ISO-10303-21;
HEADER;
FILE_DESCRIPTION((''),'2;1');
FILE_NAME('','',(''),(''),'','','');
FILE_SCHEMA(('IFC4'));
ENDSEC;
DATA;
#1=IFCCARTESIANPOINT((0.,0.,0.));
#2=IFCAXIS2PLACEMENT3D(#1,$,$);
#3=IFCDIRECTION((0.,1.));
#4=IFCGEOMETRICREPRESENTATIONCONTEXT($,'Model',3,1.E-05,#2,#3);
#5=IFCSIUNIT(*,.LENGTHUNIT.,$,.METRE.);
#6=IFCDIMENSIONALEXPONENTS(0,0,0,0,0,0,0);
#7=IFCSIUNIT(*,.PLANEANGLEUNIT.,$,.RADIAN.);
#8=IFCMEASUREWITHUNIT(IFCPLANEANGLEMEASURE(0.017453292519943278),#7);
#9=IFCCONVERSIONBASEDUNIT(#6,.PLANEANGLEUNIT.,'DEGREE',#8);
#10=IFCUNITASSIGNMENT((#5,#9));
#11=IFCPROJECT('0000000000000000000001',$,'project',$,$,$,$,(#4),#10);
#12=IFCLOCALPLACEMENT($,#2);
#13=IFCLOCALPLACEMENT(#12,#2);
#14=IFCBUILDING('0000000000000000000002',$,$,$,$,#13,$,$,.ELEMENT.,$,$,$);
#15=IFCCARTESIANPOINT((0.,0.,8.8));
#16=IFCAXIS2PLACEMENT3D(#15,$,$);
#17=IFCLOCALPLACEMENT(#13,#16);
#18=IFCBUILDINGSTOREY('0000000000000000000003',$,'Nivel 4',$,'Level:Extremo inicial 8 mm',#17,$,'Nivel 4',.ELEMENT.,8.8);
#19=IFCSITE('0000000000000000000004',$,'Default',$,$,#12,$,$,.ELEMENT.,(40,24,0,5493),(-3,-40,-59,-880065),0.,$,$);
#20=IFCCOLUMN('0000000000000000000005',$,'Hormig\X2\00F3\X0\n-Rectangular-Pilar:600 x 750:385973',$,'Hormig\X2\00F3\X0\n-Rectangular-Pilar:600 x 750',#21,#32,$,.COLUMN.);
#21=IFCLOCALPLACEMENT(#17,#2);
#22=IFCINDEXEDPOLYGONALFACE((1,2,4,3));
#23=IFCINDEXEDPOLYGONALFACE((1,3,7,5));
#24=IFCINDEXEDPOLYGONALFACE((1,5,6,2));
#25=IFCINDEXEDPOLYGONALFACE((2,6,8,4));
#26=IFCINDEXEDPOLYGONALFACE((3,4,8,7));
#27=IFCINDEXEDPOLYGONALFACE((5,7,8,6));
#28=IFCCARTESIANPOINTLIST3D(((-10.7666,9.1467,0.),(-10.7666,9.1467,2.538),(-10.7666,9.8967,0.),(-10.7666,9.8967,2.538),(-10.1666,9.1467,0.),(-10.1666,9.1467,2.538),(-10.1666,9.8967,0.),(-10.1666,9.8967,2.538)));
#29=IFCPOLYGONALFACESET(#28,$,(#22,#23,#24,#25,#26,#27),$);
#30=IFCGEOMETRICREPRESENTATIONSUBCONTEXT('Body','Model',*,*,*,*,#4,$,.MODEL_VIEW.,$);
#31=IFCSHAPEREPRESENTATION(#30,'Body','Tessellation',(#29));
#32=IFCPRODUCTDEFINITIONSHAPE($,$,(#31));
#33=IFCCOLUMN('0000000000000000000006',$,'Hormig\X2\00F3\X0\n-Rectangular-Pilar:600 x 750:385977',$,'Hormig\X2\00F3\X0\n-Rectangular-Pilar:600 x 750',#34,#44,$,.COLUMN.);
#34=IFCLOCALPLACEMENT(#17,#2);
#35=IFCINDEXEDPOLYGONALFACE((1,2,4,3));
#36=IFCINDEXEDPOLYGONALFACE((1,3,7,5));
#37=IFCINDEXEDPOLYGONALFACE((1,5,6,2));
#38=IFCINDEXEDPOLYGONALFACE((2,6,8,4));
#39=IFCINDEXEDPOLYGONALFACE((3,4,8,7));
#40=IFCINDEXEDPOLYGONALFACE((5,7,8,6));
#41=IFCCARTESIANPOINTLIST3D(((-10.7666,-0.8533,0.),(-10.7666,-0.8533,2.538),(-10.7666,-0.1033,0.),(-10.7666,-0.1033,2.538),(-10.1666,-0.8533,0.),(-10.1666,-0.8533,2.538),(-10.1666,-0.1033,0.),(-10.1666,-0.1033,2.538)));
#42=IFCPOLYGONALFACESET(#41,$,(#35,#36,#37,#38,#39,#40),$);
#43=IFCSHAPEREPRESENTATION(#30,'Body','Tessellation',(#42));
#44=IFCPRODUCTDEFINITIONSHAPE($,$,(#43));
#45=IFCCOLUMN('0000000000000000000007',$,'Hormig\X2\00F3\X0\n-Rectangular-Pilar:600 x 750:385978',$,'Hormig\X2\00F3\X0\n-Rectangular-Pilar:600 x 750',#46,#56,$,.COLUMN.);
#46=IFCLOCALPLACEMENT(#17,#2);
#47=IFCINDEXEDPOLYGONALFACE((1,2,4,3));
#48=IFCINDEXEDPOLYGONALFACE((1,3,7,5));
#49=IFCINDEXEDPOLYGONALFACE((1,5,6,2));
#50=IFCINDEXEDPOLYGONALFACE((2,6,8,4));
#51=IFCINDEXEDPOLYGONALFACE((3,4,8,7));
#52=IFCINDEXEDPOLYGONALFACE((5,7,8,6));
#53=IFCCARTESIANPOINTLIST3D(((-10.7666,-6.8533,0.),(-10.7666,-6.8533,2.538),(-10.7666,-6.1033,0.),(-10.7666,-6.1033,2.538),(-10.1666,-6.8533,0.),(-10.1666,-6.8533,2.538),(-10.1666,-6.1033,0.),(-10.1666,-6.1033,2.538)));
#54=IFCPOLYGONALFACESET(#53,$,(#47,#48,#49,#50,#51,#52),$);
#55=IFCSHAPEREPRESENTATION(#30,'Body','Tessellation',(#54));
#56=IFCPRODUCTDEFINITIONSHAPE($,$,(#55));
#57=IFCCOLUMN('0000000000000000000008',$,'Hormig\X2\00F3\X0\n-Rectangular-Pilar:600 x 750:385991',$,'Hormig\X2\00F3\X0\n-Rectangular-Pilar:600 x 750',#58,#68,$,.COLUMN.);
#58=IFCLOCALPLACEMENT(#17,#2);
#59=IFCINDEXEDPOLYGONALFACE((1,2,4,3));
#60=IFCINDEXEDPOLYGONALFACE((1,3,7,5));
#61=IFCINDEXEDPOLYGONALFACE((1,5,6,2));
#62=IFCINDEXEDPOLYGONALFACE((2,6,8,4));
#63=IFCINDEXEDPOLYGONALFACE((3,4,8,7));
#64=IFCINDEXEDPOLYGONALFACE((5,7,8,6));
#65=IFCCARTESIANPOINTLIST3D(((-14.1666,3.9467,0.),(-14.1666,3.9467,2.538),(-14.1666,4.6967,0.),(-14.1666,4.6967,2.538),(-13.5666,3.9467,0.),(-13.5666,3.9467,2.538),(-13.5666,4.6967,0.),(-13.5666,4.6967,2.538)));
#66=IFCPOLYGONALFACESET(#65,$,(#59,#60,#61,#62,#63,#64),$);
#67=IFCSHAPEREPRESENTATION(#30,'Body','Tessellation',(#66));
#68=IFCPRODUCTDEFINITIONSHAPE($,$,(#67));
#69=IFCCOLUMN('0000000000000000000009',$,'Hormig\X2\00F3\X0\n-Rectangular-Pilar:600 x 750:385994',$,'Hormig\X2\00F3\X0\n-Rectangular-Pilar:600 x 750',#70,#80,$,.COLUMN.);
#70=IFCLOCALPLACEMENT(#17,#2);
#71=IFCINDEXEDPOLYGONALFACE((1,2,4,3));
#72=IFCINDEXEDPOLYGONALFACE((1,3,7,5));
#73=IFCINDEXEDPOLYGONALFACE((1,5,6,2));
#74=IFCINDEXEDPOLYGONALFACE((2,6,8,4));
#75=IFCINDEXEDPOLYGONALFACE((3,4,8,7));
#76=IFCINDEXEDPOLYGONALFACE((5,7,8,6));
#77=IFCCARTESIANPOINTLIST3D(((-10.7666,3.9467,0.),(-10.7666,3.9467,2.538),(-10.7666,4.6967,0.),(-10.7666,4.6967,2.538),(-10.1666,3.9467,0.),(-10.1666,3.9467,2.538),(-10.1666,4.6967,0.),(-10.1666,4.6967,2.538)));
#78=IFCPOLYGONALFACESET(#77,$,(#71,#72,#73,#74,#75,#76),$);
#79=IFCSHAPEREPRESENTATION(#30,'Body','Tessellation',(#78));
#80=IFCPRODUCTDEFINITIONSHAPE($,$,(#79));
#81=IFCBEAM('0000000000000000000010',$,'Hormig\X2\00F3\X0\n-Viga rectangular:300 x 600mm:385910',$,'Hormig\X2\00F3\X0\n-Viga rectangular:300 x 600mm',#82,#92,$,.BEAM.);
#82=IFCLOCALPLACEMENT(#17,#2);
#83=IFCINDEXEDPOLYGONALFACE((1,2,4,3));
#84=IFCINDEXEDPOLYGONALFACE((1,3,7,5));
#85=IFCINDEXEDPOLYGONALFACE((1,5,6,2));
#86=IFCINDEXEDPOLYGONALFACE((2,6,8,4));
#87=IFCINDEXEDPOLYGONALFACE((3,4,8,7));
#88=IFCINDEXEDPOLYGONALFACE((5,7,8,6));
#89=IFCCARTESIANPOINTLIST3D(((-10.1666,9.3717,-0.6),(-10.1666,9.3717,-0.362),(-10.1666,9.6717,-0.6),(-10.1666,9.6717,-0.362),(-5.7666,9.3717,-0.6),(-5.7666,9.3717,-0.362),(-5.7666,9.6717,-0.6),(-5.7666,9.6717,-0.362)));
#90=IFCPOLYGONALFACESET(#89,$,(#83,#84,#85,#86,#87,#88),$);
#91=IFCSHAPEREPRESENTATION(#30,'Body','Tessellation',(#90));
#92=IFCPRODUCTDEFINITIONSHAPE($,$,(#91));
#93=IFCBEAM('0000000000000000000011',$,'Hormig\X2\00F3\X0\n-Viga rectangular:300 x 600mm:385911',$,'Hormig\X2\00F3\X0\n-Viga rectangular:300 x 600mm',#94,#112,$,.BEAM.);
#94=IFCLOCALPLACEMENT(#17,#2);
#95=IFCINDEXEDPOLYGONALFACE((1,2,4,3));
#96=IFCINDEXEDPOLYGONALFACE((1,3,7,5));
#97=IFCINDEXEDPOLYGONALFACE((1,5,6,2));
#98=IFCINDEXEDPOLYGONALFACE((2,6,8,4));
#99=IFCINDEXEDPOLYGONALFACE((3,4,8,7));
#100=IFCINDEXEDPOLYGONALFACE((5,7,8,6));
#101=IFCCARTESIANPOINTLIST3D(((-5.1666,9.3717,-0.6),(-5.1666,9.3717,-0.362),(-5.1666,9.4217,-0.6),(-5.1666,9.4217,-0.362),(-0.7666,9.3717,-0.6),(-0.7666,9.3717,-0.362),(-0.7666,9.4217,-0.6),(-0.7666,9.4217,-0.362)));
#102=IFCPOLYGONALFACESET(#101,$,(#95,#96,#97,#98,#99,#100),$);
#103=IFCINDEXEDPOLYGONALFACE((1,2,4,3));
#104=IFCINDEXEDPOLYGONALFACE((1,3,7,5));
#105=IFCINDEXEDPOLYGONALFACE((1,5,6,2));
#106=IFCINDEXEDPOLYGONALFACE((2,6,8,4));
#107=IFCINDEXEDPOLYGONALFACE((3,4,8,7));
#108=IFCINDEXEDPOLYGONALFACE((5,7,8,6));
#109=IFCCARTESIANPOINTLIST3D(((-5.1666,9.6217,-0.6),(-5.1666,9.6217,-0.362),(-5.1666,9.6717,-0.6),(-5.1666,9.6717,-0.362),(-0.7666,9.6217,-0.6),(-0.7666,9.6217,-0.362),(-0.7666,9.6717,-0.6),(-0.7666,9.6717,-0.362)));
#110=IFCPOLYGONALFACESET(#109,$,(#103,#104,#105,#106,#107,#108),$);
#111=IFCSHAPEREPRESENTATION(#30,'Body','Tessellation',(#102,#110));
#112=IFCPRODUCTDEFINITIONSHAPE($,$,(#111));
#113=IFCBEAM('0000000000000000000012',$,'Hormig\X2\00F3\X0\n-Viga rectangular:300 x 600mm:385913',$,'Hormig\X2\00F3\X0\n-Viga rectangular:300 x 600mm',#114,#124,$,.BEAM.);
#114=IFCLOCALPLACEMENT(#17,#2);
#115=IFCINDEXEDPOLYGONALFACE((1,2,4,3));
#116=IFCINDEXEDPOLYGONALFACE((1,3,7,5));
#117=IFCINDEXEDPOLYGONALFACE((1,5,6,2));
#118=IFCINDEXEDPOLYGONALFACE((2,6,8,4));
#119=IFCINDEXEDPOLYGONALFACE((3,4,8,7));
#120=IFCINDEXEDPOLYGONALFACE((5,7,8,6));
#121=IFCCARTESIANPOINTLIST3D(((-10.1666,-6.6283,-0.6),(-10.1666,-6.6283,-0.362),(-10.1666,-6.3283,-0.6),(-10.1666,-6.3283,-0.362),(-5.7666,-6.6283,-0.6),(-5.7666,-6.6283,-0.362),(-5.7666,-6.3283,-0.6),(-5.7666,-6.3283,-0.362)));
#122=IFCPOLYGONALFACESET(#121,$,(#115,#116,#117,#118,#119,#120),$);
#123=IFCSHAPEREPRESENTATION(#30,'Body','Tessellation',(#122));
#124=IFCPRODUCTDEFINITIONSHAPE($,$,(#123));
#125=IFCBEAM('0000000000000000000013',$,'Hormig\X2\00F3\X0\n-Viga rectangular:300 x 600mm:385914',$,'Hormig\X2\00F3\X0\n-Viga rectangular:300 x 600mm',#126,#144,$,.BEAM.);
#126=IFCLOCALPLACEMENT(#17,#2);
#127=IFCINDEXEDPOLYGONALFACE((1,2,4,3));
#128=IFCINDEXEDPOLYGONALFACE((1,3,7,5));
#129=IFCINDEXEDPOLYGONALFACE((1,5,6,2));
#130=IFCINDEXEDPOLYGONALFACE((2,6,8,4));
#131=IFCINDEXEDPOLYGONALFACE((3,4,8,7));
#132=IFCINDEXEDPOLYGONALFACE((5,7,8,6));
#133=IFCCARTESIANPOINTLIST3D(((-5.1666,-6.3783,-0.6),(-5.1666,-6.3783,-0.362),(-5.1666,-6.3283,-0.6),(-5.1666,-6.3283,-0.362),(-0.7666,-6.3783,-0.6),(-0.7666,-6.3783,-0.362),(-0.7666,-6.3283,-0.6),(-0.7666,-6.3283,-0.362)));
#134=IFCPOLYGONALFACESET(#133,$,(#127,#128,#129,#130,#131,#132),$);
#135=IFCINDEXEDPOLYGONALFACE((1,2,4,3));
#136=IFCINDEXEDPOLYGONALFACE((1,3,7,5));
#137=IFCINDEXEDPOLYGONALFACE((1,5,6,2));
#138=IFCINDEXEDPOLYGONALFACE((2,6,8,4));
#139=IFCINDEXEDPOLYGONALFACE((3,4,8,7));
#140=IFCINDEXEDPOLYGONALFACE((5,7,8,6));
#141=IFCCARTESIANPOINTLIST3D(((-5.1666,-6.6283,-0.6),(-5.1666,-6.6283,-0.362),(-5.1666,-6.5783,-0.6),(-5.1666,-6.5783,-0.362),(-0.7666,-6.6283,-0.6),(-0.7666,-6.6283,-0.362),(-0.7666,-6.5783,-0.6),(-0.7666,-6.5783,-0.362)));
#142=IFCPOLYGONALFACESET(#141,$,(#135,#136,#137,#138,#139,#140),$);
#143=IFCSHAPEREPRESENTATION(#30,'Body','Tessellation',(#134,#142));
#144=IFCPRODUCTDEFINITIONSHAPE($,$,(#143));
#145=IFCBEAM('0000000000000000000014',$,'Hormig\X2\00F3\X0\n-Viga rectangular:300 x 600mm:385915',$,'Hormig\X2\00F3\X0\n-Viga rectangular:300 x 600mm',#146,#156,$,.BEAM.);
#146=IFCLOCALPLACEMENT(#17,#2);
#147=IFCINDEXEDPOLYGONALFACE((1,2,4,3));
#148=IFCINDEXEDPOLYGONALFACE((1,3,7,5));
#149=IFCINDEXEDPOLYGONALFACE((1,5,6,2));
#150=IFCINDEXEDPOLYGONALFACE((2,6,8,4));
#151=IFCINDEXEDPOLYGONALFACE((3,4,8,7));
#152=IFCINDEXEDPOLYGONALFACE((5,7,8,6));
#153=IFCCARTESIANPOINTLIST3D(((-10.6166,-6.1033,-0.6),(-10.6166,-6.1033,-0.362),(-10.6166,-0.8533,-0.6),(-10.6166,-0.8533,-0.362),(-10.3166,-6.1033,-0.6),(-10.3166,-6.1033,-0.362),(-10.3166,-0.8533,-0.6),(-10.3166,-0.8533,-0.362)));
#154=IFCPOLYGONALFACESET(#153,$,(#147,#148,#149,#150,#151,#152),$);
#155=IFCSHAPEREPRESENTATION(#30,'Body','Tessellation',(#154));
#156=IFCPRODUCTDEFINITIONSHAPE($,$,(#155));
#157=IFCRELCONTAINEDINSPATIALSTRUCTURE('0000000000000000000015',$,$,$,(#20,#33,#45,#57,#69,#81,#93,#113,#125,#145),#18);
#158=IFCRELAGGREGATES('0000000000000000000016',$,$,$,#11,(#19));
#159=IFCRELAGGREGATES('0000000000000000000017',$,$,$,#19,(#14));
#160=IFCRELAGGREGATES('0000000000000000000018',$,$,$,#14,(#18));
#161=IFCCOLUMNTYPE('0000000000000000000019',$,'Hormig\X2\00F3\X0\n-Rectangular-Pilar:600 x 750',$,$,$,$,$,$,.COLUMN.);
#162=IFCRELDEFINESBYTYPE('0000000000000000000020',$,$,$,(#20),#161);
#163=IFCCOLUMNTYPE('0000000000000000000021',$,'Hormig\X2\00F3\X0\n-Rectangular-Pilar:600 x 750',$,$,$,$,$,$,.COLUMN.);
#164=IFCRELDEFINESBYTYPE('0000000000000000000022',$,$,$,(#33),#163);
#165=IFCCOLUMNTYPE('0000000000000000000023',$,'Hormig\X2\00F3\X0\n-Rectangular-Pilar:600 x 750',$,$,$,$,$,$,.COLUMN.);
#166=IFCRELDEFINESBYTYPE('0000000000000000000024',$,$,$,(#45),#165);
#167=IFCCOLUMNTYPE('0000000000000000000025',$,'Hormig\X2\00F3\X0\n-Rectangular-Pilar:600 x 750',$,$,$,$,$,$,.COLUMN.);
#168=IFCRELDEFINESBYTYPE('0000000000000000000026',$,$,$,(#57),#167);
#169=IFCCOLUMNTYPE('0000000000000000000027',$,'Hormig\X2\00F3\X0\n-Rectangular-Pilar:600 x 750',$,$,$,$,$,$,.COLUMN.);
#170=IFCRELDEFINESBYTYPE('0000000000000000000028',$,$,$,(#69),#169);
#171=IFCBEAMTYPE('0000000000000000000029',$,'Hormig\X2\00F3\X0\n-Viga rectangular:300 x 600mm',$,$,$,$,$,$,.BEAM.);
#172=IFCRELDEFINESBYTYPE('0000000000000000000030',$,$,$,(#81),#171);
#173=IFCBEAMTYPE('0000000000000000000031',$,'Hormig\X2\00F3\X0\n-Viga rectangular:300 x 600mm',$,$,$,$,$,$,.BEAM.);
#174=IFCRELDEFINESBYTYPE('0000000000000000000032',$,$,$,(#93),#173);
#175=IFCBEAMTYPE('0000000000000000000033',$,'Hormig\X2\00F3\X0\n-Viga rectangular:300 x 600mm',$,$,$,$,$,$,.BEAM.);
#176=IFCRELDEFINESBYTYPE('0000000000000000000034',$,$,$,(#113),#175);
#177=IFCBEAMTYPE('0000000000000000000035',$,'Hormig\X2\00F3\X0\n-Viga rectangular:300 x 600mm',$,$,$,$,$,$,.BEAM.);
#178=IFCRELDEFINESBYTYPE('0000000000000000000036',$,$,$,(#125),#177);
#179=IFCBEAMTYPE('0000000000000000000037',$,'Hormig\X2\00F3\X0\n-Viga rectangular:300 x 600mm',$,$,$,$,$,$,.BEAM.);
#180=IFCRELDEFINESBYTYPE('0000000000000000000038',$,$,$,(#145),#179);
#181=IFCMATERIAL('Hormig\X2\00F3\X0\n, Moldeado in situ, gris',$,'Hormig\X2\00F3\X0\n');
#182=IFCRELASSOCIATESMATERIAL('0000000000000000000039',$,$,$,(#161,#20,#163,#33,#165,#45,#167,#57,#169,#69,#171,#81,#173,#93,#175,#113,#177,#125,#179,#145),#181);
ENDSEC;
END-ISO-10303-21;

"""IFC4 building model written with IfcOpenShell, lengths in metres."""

from ifc_helpers import new_model, entity, si_unit, converted_unit, direction, frame, origin, place, context, subcontext, project, spatial, indexed_curve, outline, extrude, source, transform, mapped, material, type_object, type_shapes, element, save


model = new_model("IFC4")

# Units and contexts
model_context = context("Model", 3, precision=1e-05, world=origin(), true_north=direction((0.0, 1.0)))
body_context = subcontext(model_context, "Body", "Model", "MODEL_VIEW")
ifc_project = project(units=[si_unit("LENGTHUNIT", "METRE"), converted_unit("PLANEANGLEUNIT", "DEGREE", entity("IfcPlaneAngleMeasure", 0.017453292519943278), si_unit("PLANEANGLEUNIT", "RADIAN"), dimensions=[0, 0, 0, 0, 0, 0, 0])], contexts=[model_context])

# Site, building, storey
site_placement = place(None, origin())
site = spatial("IfcSite", under=ifc_project, at=site_placement, Name="Default", CompositionType="ELEMENT", RefLatitude=(40, 24, 0, 5493), RefLongitude=(-3, -40, -59, -880065), RefElevation=0.0)
building_placement = place(site_placement, origin())
building = spatial("IfcBuilding", under=site, at=building_placement, CompositionType="ELEMENT")
storey_placement = place(building_placement, frame((0.0, 0.0, 8.8)))
storey = spatial("IfcBuildingStorey", under=building, at=storey_placement, Name="Nivel 4", ObjectType="Level:Extremo inicial 8 mm", LongName="Nivel 4", CompositionType="ELEMENT", Elevation=8.8)

# Columns
ifc_material_1 = material(Name="Hormigón, Moldeado in situ, gris", Category="Hormigón")
column_type_1 = type_object("IfcColumnType", Name="Hormigón-Rectangular-Pilar:600 x 750", PredefinedType="COLUMN", material=ifc_material_1)
shared_shape_1 = source(origin(), body_context, "Body", "SweptSolid", [
    extrude(outline(indexed_curve([(-0.3, -0.375), (0.3, -0.375), (0.3, 0.375), (-0.3, 0.375), (-0.3, -0.375)], self_intersect=False)), frame((-10.4666, 9.5217, 8.8), z_axis=(0.0, 0.0, 1.0), x_axis=(-1.0, 0.0, 0.0)), (0.0, 0.0, 1.0), 2.538),
])
type_shapes(column_type_1, [shared_shape_1])
column_1_placement = place(storey_placement, frame((0.0, 0.0, -8.8)))
element("IfcColumn", 1, at=column_1_placement, inside=storey, type_object=column_type_1, material=ifc_material_1, Name="Hormigón-Rectangular-Pilar:600 x 750:385973", ObjectType="Hormigón-Rectangular-Pilar:600 x 750", PredefinedType="COLUMN", context=body_context, shape_type="MappedRepresentation", body=[
    mapped(shared_shape_1, transform((0.0, 0.0, 0.0), scale=1.0)),
])
column_type_2 = type_object("IfcColumnType", Name="Hormigón-Rectangular-Pilar:600 x 750", PredefinedType="COLUMN", material=ifc_material_1)
shared_shape_2 = source(origin(), body_context, "Body", "SweptSolid", [
    extrude(outline(indexed_curve([(-0.3, -0.375), (0.3, -0.375), (0.3, 0.375), (-0.3, 0.375), (-0.3, -0.375)], self_intersect=False)), frame((-10.4666, -0.4783, 8.8), z_axis=(0.0, 0.0, 1.0), x_axis=(-1.0, 0.0, 0.0)), (0.0, 0.0, 1.0), 2.538),
])
type_shapes(column_type_2, [shared_shape_2])
column_2_placement = place(storey_placement, frame((0.0, 0.0, -8.8)))
element("IfcColumn", 2, at=column_2_placement, inside=storey, type_object=column_type_2, material=ifc_material_1, Name="Hormigón-Rectangular-Pilar:600 x 750:385977", ObjectType="Hormigón-Rectangular-Pilar:600 x 750", PredefinedType="COLUMN", context=body_context, shape_type="MappedRepresentation", body=[
    mapped(shared_shape_2, transform((0.0, 0.0, 0.0), scale=1.0)),
])
column_type_3 = type_object("IfcColumnType", Name="Hormigón-Rectangular-Pilar:600 x 750", PredefinedType="COLUMN", material=ifc_material_1)
shared_shape_3 = source(origin(), body_context, "Body", "SweptSolid", [
    extrude(outline(indexed_curve([(-0.3, -0.375), (0.3, -0.375), (0.3, 0.375), (-0.3, 0.375), (-0.3, -0.375)], self_intersect=False)), frame((-10.4666, -6.4783, 8.8), z_axis=(0.0, 0.0, 1.0), x_axis=(-1.0, 0.0, 0.0)), (0.0, 0.0, 1.0), 2.538),
])
type_shapes(column_type_3, [shared_shape_3])
column_3_placement = place(storey_placement, frame((0.0, 0.0, -8.8)))
element("IfcColumn", 3, at=column_3_placement, inside=storey, type_object=column_type_3, material=ifc_material_1, Name="Hormigón-Rectangular-Pilar:600 x 750:385978", ObjectType="Hormigón-Rectangular-Pilar:600 x 750", PredefinedType="COLUMN", context=body_context, shape_type="MappedRepresentation", body=[
    mapped(shared_shape_3, transform((0.0, 0.0, 0.0), scale=1.0)),
])
column_type_4 = type_object("IfcColumnType", Name="Hormigón-Rectangular-Pilar:600 x 750", PredefinedType="COLUMN", material=ifc_material_1)
shared_shape_4 = source(origin(), body_context, "Body", "SweptSolid", [
    extrude(outline(indexed_curve([(-0.3, -0.375), (0.3, -0.375), (0.3, 0.375), (-0.3, 0.375), (-0.3, -0.375)], self_intersect=False)), frame((-13.8666, 4.3217, 8.8), z_axis=(0.0, 0.0, 1.0), x_axis=(-1.0, 0.0, 0.0)), (0.0, 0.0, 1.0), 2.538),
])
type_shapes(column_type_4, [shared_shape_4])
column_4_placement = place(storey_placement, frame((0.0, 0.0, -8.8)))
element("IfcColumn", 4, at=column_4_placement, inside=storey, type_object=column_type_4, material=ifc_material_1, Name="Hormigón-Rectangular-Pilar:600 x 750:385991", ObjectType="Hormigón-Rectangular-Pilar:600 x 750", PredefinedType="COLUMN", context=body_context, shape_type="MappedRepresentation", body=[
    mapped(shared_shape_4, transform((0.0, 0.0, 0.0), scale=1.0)),
])
column_type_5 = type_object("IfcColumnType", Name="Hormigón-Rectangular-Pilar:600 x 750", PredefinedType="COLUMN", material=ifc_material_1)
shared_shape_5 = source(origin(), body_context, "Body", "SweptSolid", [
    extrude(outline(indexed_curve([(-0.3, -0.375), (0.3, -0.375), (0.3, 0.375), (-0.3, 0.375), (-0.3, -0.375)], self_intersect=False)), frame((-10.4666, 4.3217, 8.8), z_axis=(0.0, 0.0, 1.0), x_axis=(-1.0, 0.0, 0.0)), (0.0, 0.0, 1.0), 2.538),
])
type_shapes(column_type_5, [shared_shape_5])
column_5_placement = place(storey_placement, frame((0.0, 0.0, -8.8)))
element("IfcColumn", 5, at=column_5_placement, inside=storey, type_object=column_type_5, material=ifc_material_1, Name="Hormigón-Rectangular-Pilar:600 x 750:385994", ObjectType="Hormigón-Rectangular-Pilar:600 x 750", PredefinedType="COLUMN", context=body_context, shape_type="MappedRepresentation", body=[
    mapped(shared_shape_5, transform((0.0, 0.0, 0.0), scale=1.0)),
])

# Beams
beam_type_1 = type_object("IfcBeamType", Name="Hormigón-Viga rectangular:300 x 600mm", PredefinedType="BEAM", material=ifc_material_1)
shared_shape_6 = source(origin(), body_context, "Body", "SweptSolid", [
    extrude(outline(indexed_curve([(-0.119, -0.15), (0.119, -0.15), (0.119, 0.15), (-0.119, 0.15), (-0.119, -0.15)], self_intersect=False)), frame((-5.7666, 9.5217, 8.319), z_axis=(-1.0, 0.0, 0.0), x_axis=(0.0, 0.0, -1.0)), (0.0, 0.0, 1.0), 4.4),
])
type_shapes(beam_type_1, [shared_shape_6])
beam_1_placement = place(storey_placement, frame((0.0, 0.0, -8.8)))
element("IfcBeam", 6, at=beam_1_placement, inside=storey, type_object=beam_type_1, material=ifc_material_1, Name="Hormigón-Viga rectangular:300 x 600mm:385910", ObjectType="Hormigón-Viga rectangular:300 x 600mm", PredefinedType="BEAM", context=body_context, shape_type="MappedRepresentation", body=[
    mapped(shared_shape_6, transform((0.0, 0.0, 0.0), scale=1.0)),
])
beam_type_2 = type_object("IfcBeamType", Name="Hormigón-Viga rectangular:300 x 600mm", PredefinedType="BEAM", material=ifc_material_1)
shared_shape_7 = source(origin(), body_context, "Body", "SweptSolid", [
    extrude(outline(indexed_curve([(-0.119, -0.025), (0.119, -0.025), (0.119, 0.025), (-0.119, 0.025), (-0.119, -0.025)], self_intersect=False)), frame((-5.1666, 9.3967, 8.319), z_axis=(1.0, 0.0, 0.0), x_axis=(0.0, 0.0, -1.0)), (0.0, 0.0, 1.0), 4.4),
    extrude(outline(indexed_curve([(-0.119, -0.025), (0.119, -0.025), (0.119, 0.025), (-0.119, 0.025), (-0.119, -0.025)], self_intersect=False)), frame((-5.1666, 9.6467, 8.319), z_axis=(1.0, 0.0, 0.0), x_axis=(0.0, 0.0, -1.0)), (0.0, 0.0, 1.0), 4.4),
])
type_shapes(beam_type_2, [shared_shape_7])
beam_2_placement = place(storey_placement, frame((0.0, 0.0, -8.8)))
element("IfcBeam", 7, at=beam_2_placement, inside=storey, type_object=beam_type_2, material=ifc_material_1, Name="Hormigón-Viga rectangular:300 x 600mm:385911", ObjectType="Hormigón-Viga rectangular:300 x 600mm", PredefinedType="BEAM", context=body_context, shape_type="MappedRepresentation", body=[
    mapped(shared_shape_7, transform((0.0, 0.0, 0.0), scale=1.0)),
])
beam_type_3 = type_object("IfcBeamType", Name="Hormigón-Viga rectangular:300 x 600mm", PredefinedType="BEAM", material=ifc_material_1)
shared_shape_8 = source(origin(), body_context, "Body", "SweptSolid", [
    extrude(outline(indexed_curve([(-0.119, -0.15), (0.119, -0.15), (0.119, 0.15), (-0.119, 0.15), (-0.119, -0.15)], self_intersect=False)), frame((-10.1666, -6.4783, 8.319), z_axis=(1.0, 0.0, 0.0), x_axis=(0.0, 0.0, -1.0)), (0.0, 0.0, 1.0), 4.4),
])
type_shapes(beam_type_3, [shared_shape_8])
beam_3_placement = place(storey_placement, frame((0.0, 0.0, -8.8)))
element("IfcBeam", 8, at=beam_3_placement, inside=storey, type_object=beam_type_3, material=ifc_material_1, Name="Hormigón-Viga rectangular:300 x 600mm:385913", ObjectType="Hormigón-Viga rectangular:300 x 600mm", PredefinedType="BEAM", context=body_context, shape_type="MappedRepresentation", body=[
    mapped(shared_shape_8, transform((0.0, 0.0, 0.0), scale=1.0)),
])
beam_type_4 = type_object("IfcBeamType", Name="Hormigón-Viga rectangular:300 x 600mm", PredefinedType="BEAM", material=ifc_material_1)
shared_shape_9 = source(origin(), body_context, "Body", "SweptSolid", [
    extrude(outline(indexed_curve([(-0.119, -0.025), (0.119, -0.025), (0.119, 0.025), (-0.119, 0.025), (-0.119, -0.025)], self_intersect=False)), frame((-0.7666, -6.3533, 8.319), z_axis=(-1.0, 0.0, 0.0), x_axis=(0.0, 0.0, -1.0)), (0.0, 0.0, 1.0), 4.4),
    extrude(outline(indexed_curve([(-0.119, -0.025), (0.119, -0.025), (0.119, 0.025), (-0.119, 0.025), (-0.119, -0.025)], self_intersect=False)), frame((-0.7666, -6.6033, 8.319), z_axis=(-1.0, 0.0, 0.0), x_axis=(0.0, 0.0, -1.0)), (0.0, 0.0, 1.0), 4.4),
])
type_shapes(beam_type_4, [shared_shape_9])
beam_4_placement = place(storey_placement, frame((0.0, 0.0, -8.8)))
element("IfcBeam", 9, at=beam_4_placement, inside=storey, type_object=beam_type_4, material=ifc_material_1, Name="Hormigón-Viga rectangular:300 x 600mm:385914", ObjectType="Hormigón-Viga rectangular:300 x 600mm", PredefinedType="BEAM", context=body_context, shape_type="MappedRepresentation", body=[
    mapped(shared_shape_9, transform((0.0, 0.0, 0.0), scale=1.0)),
])
beam_type_5 = type_object("IfcBeamType", Name="Hormigón-Viga rectangular:300 x 600mm", PredefinedType="BEAM", material=ifc_material_1)
shared_shape_10 = source(origin(), body_context, "Body", "SweptSolid", [
    extrude(outline(indexed_curve([(-0.15, -0.119), (0.15, -0.119), (0.15, 0.119), (-0.15, 0.119), (-0.15, -0.119)], self_intersect=False)), frame((-10.4666, -6.1033, 8.319), z_axis=(0.0, 1.0, 0.0), x_axis=(-1.0, 0.0, 0.0)), (0.0, 0.0, 1.0), 5.25),
])
type_shapes(beam_type_5, [shared_shape_10])
beam_5_placement = place(storey_placement, frame((0.0, 0.0, -8.8)))
element("IfcBeam", 10, at=beam_5_placement, inside=storey, type_object=beam_type_5, material=ifc_material_1, Name="Hormigón-Viga rectangular:300 x 600mm:385915", ObjectType="Hormigón-Viga rectangular:300 x 600mm", PredefinedType="BEAM", context=body_context, shape_type="MappedRepresentation", body=[
    mapped(shared_shape_10, transform((0.0, 0.0, 0.0), scale=1.0)),
])

save(model, "model.ifc")
